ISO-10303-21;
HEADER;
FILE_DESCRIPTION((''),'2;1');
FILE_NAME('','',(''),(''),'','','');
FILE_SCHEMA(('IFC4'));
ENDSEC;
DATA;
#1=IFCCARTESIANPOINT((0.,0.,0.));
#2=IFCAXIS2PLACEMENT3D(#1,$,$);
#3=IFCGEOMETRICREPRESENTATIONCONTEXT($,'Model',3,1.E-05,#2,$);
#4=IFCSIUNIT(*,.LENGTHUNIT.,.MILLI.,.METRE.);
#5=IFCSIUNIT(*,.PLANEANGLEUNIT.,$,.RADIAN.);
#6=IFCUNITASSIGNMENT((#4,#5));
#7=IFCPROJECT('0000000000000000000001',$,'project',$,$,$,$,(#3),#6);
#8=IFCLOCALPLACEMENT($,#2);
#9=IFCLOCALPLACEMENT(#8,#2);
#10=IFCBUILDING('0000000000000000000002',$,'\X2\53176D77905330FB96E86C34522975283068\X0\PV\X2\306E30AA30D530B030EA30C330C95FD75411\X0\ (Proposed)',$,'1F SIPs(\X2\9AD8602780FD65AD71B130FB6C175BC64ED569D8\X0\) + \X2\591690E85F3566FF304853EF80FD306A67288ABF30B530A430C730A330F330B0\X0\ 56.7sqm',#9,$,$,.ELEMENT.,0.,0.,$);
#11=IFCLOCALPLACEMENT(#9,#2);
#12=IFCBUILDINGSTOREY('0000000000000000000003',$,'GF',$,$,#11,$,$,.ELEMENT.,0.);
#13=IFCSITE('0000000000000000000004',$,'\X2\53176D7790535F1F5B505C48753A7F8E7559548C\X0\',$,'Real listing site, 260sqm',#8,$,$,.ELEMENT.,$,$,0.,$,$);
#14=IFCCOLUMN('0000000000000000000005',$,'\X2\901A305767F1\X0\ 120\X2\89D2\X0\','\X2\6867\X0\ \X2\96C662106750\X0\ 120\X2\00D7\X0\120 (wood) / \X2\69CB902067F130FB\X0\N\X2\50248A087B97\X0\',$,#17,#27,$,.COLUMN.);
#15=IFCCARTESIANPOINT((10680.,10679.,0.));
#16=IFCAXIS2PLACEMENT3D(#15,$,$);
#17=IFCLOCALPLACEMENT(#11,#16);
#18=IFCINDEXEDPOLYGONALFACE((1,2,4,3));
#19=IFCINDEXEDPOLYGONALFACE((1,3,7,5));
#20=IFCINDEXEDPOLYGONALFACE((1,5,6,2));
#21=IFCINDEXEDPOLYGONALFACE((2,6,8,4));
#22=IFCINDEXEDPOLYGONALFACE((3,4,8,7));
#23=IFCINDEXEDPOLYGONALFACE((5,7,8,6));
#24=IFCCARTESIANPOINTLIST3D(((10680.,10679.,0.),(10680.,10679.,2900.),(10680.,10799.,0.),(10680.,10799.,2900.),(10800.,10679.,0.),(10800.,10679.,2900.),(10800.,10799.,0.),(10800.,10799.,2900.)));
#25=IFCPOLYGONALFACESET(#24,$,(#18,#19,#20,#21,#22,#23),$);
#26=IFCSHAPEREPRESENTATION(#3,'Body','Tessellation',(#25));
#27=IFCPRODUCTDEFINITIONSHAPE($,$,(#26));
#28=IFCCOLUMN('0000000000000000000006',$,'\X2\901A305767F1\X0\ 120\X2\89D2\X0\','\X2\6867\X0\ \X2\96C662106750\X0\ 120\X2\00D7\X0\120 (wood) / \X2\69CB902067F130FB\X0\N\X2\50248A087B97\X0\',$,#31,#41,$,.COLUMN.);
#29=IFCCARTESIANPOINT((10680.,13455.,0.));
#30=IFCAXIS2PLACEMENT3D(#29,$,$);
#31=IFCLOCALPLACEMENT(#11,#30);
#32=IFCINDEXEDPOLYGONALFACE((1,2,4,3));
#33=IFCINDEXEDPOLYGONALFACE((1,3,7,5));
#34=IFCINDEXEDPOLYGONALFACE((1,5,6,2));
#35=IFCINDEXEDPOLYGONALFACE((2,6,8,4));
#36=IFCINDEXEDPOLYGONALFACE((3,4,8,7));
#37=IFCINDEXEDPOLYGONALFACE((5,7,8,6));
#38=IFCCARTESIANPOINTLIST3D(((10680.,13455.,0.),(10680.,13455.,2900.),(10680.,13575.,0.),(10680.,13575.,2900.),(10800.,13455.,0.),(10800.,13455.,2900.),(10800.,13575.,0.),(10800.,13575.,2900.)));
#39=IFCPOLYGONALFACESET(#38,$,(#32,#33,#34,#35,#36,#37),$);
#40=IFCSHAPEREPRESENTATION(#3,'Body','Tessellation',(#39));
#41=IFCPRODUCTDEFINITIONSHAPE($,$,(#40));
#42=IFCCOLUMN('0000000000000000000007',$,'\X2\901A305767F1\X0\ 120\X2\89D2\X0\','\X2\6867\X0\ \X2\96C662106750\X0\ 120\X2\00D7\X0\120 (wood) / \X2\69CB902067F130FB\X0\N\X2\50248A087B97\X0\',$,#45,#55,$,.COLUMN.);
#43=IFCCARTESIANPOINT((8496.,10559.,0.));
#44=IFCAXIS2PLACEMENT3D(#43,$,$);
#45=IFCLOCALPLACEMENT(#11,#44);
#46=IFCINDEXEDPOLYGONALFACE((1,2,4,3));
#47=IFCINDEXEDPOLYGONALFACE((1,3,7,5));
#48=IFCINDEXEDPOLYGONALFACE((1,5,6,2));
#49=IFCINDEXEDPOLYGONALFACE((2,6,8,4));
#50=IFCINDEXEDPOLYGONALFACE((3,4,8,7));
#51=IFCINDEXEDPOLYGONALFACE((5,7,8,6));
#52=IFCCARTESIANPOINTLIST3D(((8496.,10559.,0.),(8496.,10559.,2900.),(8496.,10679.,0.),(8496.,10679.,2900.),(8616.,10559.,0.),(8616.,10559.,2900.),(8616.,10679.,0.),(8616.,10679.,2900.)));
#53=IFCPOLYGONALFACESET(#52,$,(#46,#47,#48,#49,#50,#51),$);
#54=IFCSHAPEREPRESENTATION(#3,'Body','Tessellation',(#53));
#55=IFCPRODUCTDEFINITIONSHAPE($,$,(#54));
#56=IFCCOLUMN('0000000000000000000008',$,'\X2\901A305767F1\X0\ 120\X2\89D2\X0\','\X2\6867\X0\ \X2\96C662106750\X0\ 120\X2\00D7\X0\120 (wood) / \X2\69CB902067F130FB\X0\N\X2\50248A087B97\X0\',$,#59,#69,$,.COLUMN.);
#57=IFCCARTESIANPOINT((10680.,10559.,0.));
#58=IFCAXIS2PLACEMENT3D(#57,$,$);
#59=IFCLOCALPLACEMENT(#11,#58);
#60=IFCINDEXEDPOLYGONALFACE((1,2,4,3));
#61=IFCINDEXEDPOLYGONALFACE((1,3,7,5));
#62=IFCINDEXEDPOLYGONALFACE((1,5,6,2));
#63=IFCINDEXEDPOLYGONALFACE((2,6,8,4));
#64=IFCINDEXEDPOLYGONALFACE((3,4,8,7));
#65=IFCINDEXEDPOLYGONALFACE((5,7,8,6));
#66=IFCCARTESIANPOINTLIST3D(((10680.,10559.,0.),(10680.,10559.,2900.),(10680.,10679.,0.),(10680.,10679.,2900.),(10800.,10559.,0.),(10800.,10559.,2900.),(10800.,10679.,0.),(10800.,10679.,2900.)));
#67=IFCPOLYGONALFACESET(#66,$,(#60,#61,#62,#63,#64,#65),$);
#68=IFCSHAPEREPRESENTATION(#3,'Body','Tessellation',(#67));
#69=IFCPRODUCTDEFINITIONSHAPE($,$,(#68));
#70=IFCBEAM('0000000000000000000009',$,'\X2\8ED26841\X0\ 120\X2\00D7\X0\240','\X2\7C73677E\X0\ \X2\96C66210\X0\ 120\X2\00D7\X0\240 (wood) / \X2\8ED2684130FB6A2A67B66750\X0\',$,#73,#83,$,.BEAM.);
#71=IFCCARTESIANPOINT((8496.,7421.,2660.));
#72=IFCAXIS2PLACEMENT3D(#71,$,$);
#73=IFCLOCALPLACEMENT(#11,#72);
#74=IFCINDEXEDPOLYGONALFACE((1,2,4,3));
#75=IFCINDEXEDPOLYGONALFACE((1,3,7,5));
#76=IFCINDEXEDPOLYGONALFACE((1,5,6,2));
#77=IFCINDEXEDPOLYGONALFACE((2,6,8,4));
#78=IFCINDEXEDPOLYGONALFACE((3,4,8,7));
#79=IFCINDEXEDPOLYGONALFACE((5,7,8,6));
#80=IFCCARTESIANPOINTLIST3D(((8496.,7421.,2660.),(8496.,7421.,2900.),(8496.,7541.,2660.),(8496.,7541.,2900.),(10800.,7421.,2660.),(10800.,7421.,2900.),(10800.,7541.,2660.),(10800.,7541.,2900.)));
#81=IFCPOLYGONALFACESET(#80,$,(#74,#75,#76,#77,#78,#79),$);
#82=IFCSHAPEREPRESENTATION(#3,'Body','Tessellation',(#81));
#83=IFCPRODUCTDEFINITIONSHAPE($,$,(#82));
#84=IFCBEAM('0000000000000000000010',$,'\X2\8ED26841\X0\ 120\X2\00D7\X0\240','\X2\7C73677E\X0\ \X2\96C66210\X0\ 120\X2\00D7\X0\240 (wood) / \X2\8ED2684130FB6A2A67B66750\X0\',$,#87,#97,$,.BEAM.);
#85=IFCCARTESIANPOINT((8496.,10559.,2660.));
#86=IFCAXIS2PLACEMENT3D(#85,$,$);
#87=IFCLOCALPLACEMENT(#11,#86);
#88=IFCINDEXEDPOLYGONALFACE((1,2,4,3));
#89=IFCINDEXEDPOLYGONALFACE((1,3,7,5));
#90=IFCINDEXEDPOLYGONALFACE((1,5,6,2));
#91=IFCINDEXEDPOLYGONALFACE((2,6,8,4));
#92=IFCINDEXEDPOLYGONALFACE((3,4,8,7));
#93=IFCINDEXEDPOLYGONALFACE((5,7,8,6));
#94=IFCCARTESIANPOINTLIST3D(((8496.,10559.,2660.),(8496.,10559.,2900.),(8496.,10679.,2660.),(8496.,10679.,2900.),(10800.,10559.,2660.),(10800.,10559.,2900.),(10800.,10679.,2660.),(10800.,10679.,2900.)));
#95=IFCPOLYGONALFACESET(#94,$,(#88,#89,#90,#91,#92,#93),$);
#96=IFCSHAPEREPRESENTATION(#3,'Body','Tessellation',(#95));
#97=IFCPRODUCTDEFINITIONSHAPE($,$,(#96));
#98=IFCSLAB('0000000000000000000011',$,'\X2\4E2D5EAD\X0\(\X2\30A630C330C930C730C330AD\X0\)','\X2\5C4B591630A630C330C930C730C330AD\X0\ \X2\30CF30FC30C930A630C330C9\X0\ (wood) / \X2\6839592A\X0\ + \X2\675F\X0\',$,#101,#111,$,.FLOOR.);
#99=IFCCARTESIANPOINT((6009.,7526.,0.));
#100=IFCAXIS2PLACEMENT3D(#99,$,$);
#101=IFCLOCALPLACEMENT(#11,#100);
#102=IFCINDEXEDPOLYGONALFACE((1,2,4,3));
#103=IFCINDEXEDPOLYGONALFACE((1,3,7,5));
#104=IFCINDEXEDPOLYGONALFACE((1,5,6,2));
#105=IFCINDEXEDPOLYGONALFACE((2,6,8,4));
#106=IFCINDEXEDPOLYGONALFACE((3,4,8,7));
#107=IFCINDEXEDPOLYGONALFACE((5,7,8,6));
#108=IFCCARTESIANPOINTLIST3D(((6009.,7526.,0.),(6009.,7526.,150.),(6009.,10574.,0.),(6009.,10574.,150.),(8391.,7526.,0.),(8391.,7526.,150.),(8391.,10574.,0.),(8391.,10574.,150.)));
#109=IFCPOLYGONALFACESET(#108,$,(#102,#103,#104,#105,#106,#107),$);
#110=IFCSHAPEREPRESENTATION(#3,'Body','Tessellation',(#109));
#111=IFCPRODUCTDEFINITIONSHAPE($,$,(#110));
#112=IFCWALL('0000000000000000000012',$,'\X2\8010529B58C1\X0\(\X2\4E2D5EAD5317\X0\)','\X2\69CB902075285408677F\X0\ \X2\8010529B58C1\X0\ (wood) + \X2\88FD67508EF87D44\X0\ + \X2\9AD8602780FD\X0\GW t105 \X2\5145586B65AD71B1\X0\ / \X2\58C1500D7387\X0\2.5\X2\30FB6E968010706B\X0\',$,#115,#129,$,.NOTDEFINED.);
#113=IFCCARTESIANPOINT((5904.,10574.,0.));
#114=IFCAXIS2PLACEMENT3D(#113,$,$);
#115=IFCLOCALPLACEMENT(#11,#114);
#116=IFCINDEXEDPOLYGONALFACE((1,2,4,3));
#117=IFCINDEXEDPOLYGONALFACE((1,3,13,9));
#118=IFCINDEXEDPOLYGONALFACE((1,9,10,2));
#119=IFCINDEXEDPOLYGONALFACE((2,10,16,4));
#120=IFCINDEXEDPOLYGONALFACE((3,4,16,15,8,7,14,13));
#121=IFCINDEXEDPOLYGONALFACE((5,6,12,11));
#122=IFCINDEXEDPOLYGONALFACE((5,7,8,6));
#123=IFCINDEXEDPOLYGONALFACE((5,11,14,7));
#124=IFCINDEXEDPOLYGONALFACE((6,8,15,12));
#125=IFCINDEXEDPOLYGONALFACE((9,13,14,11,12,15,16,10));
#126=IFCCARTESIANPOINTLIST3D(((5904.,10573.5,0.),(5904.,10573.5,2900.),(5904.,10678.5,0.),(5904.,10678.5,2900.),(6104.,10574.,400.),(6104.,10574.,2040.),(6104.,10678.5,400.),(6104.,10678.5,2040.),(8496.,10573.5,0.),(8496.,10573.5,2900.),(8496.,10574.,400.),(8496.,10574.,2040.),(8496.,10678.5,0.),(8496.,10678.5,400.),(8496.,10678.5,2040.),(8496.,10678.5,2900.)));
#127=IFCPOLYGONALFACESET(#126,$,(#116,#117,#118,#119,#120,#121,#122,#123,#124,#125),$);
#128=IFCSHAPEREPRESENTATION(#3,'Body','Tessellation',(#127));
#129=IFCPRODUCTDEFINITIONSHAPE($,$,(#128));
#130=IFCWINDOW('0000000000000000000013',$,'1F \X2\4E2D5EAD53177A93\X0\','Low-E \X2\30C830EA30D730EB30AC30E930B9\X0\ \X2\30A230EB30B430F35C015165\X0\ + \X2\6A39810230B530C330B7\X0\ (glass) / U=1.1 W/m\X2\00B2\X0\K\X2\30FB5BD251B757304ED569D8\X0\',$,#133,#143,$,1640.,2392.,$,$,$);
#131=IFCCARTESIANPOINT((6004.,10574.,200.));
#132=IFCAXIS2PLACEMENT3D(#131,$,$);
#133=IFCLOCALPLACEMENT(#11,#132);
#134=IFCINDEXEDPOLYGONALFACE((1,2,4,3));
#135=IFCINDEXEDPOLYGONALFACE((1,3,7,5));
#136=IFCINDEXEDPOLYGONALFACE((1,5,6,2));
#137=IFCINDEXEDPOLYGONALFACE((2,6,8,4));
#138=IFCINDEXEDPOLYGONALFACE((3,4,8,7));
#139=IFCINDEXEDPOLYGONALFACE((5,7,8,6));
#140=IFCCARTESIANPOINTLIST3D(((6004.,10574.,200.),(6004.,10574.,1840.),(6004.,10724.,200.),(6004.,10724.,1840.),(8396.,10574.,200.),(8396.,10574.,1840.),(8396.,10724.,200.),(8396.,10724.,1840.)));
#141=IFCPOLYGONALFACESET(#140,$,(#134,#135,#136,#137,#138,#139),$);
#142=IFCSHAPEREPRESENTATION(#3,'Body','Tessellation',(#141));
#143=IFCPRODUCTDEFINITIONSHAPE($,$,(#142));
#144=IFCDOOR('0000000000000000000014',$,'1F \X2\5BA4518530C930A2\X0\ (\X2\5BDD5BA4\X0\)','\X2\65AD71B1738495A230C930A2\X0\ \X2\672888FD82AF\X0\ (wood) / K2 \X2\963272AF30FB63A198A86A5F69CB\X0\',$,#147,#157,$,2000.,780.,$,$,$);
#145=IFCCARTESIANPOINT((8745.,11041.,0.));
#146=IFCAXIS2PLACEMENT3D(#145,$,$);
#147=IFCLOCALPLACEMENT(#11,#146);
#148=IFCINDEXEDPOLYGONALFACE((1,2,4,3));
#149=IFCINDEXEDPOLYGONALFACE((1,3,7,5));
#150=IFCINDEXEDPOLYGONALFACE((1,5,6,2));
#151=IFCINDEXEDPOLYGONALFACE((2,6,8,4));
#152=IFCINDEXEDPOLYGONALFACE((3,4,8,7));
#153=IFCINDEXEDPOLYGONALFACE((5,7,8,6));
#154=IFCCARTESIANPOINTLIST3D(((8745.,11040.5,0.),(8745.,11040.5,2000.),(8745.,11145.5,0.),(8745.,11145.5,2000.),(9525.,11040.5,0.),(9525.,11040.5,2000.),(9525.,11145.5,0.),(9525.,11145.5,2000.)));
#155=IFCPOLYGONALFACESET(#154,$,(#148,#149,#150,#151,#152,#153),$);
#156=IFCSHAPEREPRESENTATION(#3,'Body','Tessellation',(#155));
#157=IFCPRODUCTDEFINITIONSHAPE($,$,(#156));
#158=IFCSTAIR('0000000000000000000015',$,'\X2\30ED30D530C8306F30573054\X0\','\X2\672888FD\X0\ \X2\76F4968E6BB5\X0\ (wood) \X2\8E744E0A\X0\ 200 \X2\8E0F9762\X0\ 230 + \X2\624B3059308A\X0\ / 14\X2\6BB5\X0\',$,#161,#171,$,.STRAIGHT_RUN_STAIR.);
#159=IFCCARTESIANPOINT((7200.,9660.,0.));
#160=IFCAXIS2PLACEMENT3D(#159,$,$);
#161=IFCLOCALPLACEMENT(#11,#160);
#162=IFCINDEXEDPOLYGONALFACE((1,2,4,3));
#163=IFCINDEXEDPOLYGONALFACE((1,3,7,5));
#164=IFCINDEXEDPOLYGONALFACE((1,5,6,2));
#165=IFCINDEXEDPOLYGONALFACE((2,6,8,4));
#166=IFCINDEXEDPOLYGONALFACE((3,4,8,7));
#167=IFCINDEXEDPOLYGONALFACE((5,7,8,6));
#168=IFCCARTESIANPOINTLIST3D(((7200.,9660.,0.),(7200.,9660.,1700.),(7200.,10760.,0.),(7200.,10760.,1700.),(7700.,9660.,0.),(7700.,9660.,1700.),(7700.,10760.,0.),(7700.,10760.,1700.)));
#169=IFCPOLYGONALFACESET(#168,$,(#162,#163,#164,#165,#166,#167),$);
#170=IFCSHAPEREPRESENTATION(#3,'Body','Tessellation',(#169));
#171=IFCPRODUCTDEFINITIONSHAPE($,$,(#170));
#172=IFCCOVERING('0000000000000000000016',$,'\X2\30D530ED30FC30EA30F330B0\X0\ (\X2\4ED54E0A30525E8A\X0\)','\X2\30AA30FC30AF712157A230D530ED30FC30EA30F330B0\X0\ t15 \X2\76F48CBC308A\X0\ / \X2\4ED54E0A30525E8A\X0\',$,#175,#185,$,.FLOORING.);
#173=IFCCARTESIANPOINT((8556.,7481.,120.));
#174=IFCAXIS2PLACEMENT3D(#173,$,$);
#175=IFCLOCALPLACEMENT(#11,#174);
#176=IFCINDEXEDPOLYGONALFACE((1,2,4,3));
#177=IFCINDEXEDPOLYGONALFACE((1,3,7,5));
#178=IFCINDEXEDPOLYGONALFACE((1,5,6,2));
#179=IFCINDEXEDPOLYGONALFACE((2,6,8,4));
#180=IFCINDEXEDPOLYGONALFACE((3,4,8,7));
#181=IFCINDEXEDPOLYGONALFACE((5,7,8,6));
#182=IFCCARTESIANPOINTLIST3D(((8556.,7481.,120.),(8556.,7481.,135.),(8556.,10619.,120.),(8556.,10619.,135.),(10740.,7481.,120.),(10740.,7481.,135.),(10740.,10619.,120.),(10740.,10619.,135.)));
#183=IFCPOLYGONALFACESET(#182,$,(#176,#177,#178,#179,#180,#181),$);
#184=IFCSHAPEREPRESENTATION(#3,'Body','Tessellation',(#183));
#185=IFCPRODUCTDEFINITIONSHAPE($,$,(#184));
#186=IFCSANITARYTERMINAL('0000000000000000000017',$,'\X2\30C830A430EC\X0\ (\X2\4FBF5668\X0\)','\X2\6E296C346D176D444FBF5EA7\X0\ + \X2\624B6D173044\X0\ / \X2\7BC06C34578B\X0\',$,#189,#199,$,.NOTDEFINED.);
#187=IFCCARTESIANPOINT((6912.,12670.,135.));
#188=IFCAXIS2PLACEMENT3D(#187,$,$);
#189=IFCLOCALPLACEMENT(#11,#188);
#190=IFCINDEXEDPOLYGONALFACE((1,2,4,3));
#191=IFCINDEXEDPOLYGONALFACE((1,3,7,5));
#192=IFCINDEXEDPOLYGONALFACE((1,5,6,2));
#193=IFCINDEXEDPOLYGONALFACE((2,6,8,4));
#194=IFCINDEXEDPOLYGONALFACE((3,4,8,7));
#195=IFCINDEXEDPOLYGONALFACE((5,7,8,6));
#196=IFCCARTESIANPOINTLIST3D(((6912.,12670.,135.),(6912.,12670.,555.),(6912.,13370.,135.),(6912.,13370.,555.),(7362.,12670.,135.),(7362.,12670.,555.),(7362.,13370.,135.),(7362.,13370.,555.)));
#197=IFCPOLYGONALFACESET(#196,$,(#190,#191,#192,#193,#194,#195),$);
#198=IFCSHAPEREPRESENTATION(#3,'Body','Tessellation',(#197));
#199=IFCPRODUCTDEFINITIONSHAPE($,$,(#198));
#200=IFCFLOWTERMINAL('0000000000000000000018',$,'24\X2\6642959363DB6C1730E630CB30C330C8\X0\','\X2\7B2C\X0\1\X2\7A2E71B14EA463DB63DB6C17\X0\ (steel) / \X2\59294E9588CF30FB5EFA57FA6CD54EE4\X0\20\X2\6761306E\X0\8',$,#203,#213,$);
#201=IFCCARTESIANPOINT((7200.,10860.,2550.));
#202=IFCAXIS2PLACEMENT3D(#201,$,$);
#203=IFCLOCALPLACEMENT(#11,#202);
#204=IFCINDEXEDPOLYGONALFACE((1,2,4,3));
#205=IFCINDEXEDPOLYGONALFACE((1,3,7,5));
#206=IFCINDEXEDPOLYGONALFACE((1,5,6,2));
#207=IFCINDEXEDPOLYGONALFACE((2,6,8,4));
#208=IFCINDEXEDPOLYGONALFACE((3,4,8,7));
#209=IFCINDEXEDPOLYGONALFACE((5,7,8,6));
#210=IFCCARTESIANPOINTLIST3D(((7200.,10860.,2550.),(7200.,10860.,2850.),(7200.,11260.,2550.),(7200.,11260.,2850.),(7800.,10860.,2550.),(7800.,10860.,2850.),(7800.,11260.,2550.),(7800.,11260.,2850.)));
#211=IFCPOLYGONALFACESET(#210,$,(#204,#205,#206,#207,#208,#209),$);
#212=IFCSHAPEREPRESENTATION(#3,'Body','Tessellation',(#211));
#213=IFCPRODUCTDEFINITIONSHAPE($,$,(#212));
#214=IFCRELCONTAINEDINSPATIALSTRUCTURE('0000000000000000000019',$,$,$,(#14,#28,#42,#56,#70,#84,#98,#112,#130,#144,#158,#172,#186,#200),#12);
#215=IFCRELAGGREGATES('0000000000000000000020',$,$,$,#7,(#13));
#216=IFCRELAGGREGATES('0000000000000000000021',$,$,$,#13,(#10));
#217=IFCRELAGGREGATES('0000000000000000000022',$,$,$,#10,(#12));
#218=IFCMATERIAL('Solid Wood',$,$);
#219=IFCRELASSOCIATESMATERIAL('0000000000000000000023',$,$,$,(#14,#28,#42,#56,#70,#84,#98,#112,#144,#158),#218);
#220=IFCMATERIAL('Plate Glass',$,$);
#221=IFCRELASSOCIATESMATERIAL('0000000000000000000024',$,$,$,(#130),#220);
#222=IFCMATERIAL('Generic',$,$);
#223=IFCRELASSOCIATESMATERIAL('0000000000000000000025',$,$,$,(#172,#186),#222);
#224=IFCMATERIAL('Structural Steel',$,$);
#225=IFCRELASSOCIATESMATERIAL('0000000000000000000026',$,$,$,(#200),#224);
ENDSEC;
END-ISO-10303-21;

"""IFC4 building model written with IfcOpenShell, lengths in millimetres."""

from ifc_helpers import new_model, si_unit, frame, frame_2d, origin, place, context, project, spatial, rectangle, extrude, material, element, fill, save


model = new_model("IFC4")

# Units and contexts
model_context = context("Model", 3, precision=1e-05, world=origin())
ifc_project = project(units=[si_unit("LENGTHUNIT", "METRE", prefix="MILLI"), si_unit("PLANEANGLEUNIT", "RADIAN")], contexts=[model_context])

# Site, building, storey
site_placement = place(None, origin())
site = spatial("IfcSite", under=ifc_project, at=site_placement, Name="北海道弟子屈町美留和", ObjectType="Real listing site, 260sqm", CompositionType="ELEMENT", RefElevation=0.0)
building_placement = place(site_placement, origin())
building = spatial("IfcBuilding", under=site, at=building_placement, Name="北海道・雨水利用とPVのオフグリッド志向 (Proposed)", ObjectType="1F SIPs(高性能断熱・気密仕様) + 外部張替え可能な木調サイディング 56.7sqm", CompositionType="ELEMENT", ElevationOfRefHeight=0.0, ElevationOfTerrain=0.0)
storey_placement = place(building_placement, origin())
storey = spatial("IfcBuildingStorey", under=building, at=storey_placement, Name="GF", CompositionType="ELEMENT", Elevation=0.0)

# Columns
ifc_material_1 = material(Name="Solid Wood")
column_1_placement = place(storey_placement, frame((10680.0, 10679.0, 0.0)))
element("IfcColumn", 1, at=column_1_placement, inside=storey, material=ifc_material_1, Name="通し柱 120角", Description="桧 集成材 120×120 (wood) / 構造柱・N値計算", PredefinedType="COLUMN", context=model_context, shape_type="SweptSolid", body=[
    extrude(rectangle(XDim=120.0, YDim=120.0, at=frame_2d((60.0, 60.0))), frame((10680.0, 10679.0, 0.0)), (0.0, 0.0, 1.0), 2900.0),
])
column_2_placement = place(storey_placement, frame((10680.0, 13455.0, 0.0)))
element("IfcColumn", 2, at=column_2_placement, inside=storey, material=ifc_material_1, Name="通し柱 120角", Description="桧 集成材 120×120 (wood) / 構造柱・N値計算", PredefinedType="COLUMN", context=model_context, shape_type="SweptSolid", body=[
    extrude(rectangle(XDim=120.0, YDim=120.0, at=frame_2d((60.0, 60.0))), frame((10680.0, 13455.0, 0.0)), (0.0, 0.0, 1.0), 2900.0),
])
column_3_placement = place(storey_placement, frame((8496.0, 10559.0, 0.0)))
element("IfcColumn", 3, at=column_3_placement, inside=storey, material=ifc_material_1, Name="通し柱 120角", Description="桧 集成材 120×120 (wood) / 構造柱・N値計算", PredefinedType="COLUMN", context=model_context, shape_type="SweptSolid", body=[
    extrude(rectangle(XDim=120.0, YDim=120.0, at=frame_2d((60.0, 60.0))), frame((8496.0, 10559.0, 0.0)), (0.0, 0.0, 1.0), 2900.0),
])
column_4_placement = place(storey_placement, frame((10680.0, 10559.0, 0.0)))
element("IfcColumn", 4, at=column_4_placement, inside=storey, material=ifc_material_1, Name="通し柱 120角", Description="桧 集成材 120×120 (wood) / 構造柱・N値計算", PredefinedType="COLUMN", context=model_context, shape_type="SweptSolid", body=[
    extrude(rectangle(XDim=120.0, YDim=120.0, at=frame_2d((60.0, 60.0))), frame((10680.0, 10559.0, 0.0)), (0.0, 0.0, 1.0), 2900.0),
])

# Beams
beam_1_placement = place(storey_placement, frame((8496.0, 7421.0, 2660.0)))
element("IfcBeam", 5, at=beam_1_placement, inside=storey, material=ifc_material_1, Name="軒桁 120×240", Description="米松 集成 120×240 (wood) / 軒桁・横架材", PredefinedType="BEAM", context=model_context, shape_type="SweptSolid", body=[
    extrude(rectangle(XDim=2304.0, YDim=120.0, at=frame_2d((1152.0, 60.0))), frame((8496.0, 7421.0, 2660.0)), (0.0, 0.0, 1.0), 240.0),
])
beam_2_placement = place(storey_placement, frame((8496.0, 10559.0, 2660.0)))
element("IfcBeam", 6, at=beam_2_placement, inside=storey, material=ifc_material_1, Name="軒桁 120×240", Description="米松 集成 120×240 (wood) / 軒桁・横架材", PredefinedType="BEAM", context=model_context, shape_type="SweptSolid", body=[
    extrude(rectangle(XDim=2304.0, YDim=120.0, at=frame_2d((1152.0, 60.0))), frame((8496.0, 10559.0, 2660.0)), (0.0, 0.0, 1.0), 240.0),
])

# Slab
slab_placement = place(storey_placement, frame((6009.0, 7526.0, 0.0)))
element("IfcSlab", 7, at=slab_placement, inside=storey, material=ifc_material_1, Name="中庭(ウッドデッキ)", Description="屋外ウッドデッキ ハードウッド (wood) / 根太 + 束", PredefinedType="FLOOR", context=model_context, shape_type="SweptSolid", body=[
    extrude(rectangle(XDim=2382.0, YDim=3048.0, at=frame_2d((1191.0, 1524.0))), frame((6009.0, 7526.0, 0.0)), (0.0, 0.0, 1.0), 150.0),
])

# Wall, opening, window
wall_1_placement = place(storey_placement, frame((5904.0, 10574.0, 0.0)))
wall_1 = element("IfcWall", 8, at=wall_1_placement, inside=storey, material=ifc_material_1, Name="耐力壁(中庭北)", Description="構造用合板 耐力壁 (wood) + 製材軸組 + 高性能GW t105 充填断熱 / 壁倍率2.5・準耐火", PredefinedType="NOTDEFINED", context=model_context, shape_type="SweptSolid", body=[
    extrude(rectangle(XDim=2592.0, YDim=105.0, at=frame_2d((1296.0, 52.0))), frame((5904.0, 10574.0, 0.0)), (0.0, 0.0, 1.0), 2900.0),
])
opening_placement = place(storey_placement, frame((6004.0, 10574.0, 200.0)))
opening = element("IfcOpeningElement", 9, at=opening_placement, cuts=wall_1, PredefinedType="NOTDEFINED", context=model_context, shape_type="SweptSolid", body=[
    extrude(rectangle(XDim=2392.0, YDim=150.0, at=frame_2d((1196.0, 75.0))), frame((6004.0, 10574.0, 200.0)), (0.0, 0.0, 1.0), 1640.0),
])
ifc_material_2 = material(Name="Plate Glass")
window_placement = place(storey_placement, frame((6004.0, 10574.0, 200.0)))
window = element("IfcWindow", 10, at=window_placement, inside=storey, material=ifc_material_2, Name="1F 中庭北窓", Description="Low-E トリプルガラス アルゴン封入 + 樹脂サッシ (glass) / U=1.1 W/m²K・寒冷地仕様", OverallHeight=1640.0, OverallWidth=2392.0, context=model_context, shape_type="SweptSolid", body=[
    extrude(rectangle(XDim=2392.0, YDim=150.0, at=frame_2d((1196.0, 75.0))), frame((6004.0, 10574.0, 200.0)), (0.0, 0.0, 1.0), 1640.0),
])
fill(opening, window)

# Door
door_placement = place(storey_placement, frame((8745.0, 11041.0, 0.0)))
element("IfcDoor", 11, at=door_placement, inside=storey, material=ifc_material_1, Name="1F 室内ドア (寝室)", Description="断熱玄関ドア 木製芯 (wood) / K2 防犯・採風機構", OverallHeight=2000.0, OverallWidth=780.0, context=model_context, shape_type="SweptSolid", body=[
    extrude(rectangle(XDim=780.0, YDim=105.0, at=frame_2d((390.0, 52.0))), frame((8745.0, 11041.0, 0.0)), (0.0, 0.0, 1.0), 2000.0),
])

# Stair
stair_placement = place(storey_placement, frame((7200.0, 9660.0, 0.0)))
element("IfcStair", 12, at=stair_placement, inside=storey, material=ifc_material_1, Name="ロフトはしご", Description="木製 直階段 (wood) 蹴上 200 踏面 230 + 手すり / 14段", PredefinedType="STRAIGHT_RUN_STAIR", context=model_context, shape_type="SweptSolid", body=[
    extrude(rectangle(XDim=500.0, YDim=1100.0, at=frame_2d((250.0, 550.0))), frame((7200.0, 9660.0, 0.0)), (0.0, 0.0, 1.0), 1700.0),
])

# Covering
ifc_material_3 = material(Name="Generic")
covering_placement = place(storey_placement, frame((8556.0, 7481.0, 120.0)))
element("IfcCovering", 13, at=covering_placement, inside=storey, material=ifc_material_3, Name="フローリング (仕上げ床)", Description="オーク無垢フローリング t15 直貼り / 仕上げ床", PredefinedType="FLOORING", context=model_context, shape_type="SweptSolid", body=[
    extrude(rectangle(XDim=2184.0, YDim=3138.0, at=frame_2d((1092.0, 1569.0))), frame((8556.0, 7481.0, 120.0)), (0.0, 0.0, 1.0), 15.0),
])

# Sanitary terminal
sanitary_terminal_placement = place(storey_placement, frame((6912.0, 12670.0, 135.0)))
element("IfcSanitaryTerminal", 14, at=sanitary_terminal_placement, inside=storey, material=ifc_material_3, Name="トイレ (便器)", Description="温水洗浄便座 + 手洗い / 節水型", PredefinedType="NOTDEFINED", context=model_context, shape_type="SweptSolid", body=[
    extrude(rectangle(XDim=450.0, YDim=700.0, at=frame_2d((225.0, 350.0))), frame((6912.0, 12670.0, 135.0)), (0.0, 0.0, 1.0), 420.0),
])

# Flow terminal
ifc_material_4 = material(Name="Structural Steel")
flow_terminal_placement = place(storey_placement, frame((7200.0, 10860.0, 2550.0)))
element("IfcFlowTerminal", 15, at=flow_terminal_placement, inside=storey, material=ifc_material_4, Name="24時間換気ユニット", Description="第1種熱交換換気 (steel) / 天井裏・建基法令20条の8", context=model_context, shape_type="SweptSolid", body=[
    extrude(rectangle(XDim=600.0, YDim=400.0, at=frame_2d((300.0, 200.0))), frame((7200.0, 10860.0, 2550.0)), (0.0, 0.0, 1.0), 300.0),
])

save(model, "model.ifc")
